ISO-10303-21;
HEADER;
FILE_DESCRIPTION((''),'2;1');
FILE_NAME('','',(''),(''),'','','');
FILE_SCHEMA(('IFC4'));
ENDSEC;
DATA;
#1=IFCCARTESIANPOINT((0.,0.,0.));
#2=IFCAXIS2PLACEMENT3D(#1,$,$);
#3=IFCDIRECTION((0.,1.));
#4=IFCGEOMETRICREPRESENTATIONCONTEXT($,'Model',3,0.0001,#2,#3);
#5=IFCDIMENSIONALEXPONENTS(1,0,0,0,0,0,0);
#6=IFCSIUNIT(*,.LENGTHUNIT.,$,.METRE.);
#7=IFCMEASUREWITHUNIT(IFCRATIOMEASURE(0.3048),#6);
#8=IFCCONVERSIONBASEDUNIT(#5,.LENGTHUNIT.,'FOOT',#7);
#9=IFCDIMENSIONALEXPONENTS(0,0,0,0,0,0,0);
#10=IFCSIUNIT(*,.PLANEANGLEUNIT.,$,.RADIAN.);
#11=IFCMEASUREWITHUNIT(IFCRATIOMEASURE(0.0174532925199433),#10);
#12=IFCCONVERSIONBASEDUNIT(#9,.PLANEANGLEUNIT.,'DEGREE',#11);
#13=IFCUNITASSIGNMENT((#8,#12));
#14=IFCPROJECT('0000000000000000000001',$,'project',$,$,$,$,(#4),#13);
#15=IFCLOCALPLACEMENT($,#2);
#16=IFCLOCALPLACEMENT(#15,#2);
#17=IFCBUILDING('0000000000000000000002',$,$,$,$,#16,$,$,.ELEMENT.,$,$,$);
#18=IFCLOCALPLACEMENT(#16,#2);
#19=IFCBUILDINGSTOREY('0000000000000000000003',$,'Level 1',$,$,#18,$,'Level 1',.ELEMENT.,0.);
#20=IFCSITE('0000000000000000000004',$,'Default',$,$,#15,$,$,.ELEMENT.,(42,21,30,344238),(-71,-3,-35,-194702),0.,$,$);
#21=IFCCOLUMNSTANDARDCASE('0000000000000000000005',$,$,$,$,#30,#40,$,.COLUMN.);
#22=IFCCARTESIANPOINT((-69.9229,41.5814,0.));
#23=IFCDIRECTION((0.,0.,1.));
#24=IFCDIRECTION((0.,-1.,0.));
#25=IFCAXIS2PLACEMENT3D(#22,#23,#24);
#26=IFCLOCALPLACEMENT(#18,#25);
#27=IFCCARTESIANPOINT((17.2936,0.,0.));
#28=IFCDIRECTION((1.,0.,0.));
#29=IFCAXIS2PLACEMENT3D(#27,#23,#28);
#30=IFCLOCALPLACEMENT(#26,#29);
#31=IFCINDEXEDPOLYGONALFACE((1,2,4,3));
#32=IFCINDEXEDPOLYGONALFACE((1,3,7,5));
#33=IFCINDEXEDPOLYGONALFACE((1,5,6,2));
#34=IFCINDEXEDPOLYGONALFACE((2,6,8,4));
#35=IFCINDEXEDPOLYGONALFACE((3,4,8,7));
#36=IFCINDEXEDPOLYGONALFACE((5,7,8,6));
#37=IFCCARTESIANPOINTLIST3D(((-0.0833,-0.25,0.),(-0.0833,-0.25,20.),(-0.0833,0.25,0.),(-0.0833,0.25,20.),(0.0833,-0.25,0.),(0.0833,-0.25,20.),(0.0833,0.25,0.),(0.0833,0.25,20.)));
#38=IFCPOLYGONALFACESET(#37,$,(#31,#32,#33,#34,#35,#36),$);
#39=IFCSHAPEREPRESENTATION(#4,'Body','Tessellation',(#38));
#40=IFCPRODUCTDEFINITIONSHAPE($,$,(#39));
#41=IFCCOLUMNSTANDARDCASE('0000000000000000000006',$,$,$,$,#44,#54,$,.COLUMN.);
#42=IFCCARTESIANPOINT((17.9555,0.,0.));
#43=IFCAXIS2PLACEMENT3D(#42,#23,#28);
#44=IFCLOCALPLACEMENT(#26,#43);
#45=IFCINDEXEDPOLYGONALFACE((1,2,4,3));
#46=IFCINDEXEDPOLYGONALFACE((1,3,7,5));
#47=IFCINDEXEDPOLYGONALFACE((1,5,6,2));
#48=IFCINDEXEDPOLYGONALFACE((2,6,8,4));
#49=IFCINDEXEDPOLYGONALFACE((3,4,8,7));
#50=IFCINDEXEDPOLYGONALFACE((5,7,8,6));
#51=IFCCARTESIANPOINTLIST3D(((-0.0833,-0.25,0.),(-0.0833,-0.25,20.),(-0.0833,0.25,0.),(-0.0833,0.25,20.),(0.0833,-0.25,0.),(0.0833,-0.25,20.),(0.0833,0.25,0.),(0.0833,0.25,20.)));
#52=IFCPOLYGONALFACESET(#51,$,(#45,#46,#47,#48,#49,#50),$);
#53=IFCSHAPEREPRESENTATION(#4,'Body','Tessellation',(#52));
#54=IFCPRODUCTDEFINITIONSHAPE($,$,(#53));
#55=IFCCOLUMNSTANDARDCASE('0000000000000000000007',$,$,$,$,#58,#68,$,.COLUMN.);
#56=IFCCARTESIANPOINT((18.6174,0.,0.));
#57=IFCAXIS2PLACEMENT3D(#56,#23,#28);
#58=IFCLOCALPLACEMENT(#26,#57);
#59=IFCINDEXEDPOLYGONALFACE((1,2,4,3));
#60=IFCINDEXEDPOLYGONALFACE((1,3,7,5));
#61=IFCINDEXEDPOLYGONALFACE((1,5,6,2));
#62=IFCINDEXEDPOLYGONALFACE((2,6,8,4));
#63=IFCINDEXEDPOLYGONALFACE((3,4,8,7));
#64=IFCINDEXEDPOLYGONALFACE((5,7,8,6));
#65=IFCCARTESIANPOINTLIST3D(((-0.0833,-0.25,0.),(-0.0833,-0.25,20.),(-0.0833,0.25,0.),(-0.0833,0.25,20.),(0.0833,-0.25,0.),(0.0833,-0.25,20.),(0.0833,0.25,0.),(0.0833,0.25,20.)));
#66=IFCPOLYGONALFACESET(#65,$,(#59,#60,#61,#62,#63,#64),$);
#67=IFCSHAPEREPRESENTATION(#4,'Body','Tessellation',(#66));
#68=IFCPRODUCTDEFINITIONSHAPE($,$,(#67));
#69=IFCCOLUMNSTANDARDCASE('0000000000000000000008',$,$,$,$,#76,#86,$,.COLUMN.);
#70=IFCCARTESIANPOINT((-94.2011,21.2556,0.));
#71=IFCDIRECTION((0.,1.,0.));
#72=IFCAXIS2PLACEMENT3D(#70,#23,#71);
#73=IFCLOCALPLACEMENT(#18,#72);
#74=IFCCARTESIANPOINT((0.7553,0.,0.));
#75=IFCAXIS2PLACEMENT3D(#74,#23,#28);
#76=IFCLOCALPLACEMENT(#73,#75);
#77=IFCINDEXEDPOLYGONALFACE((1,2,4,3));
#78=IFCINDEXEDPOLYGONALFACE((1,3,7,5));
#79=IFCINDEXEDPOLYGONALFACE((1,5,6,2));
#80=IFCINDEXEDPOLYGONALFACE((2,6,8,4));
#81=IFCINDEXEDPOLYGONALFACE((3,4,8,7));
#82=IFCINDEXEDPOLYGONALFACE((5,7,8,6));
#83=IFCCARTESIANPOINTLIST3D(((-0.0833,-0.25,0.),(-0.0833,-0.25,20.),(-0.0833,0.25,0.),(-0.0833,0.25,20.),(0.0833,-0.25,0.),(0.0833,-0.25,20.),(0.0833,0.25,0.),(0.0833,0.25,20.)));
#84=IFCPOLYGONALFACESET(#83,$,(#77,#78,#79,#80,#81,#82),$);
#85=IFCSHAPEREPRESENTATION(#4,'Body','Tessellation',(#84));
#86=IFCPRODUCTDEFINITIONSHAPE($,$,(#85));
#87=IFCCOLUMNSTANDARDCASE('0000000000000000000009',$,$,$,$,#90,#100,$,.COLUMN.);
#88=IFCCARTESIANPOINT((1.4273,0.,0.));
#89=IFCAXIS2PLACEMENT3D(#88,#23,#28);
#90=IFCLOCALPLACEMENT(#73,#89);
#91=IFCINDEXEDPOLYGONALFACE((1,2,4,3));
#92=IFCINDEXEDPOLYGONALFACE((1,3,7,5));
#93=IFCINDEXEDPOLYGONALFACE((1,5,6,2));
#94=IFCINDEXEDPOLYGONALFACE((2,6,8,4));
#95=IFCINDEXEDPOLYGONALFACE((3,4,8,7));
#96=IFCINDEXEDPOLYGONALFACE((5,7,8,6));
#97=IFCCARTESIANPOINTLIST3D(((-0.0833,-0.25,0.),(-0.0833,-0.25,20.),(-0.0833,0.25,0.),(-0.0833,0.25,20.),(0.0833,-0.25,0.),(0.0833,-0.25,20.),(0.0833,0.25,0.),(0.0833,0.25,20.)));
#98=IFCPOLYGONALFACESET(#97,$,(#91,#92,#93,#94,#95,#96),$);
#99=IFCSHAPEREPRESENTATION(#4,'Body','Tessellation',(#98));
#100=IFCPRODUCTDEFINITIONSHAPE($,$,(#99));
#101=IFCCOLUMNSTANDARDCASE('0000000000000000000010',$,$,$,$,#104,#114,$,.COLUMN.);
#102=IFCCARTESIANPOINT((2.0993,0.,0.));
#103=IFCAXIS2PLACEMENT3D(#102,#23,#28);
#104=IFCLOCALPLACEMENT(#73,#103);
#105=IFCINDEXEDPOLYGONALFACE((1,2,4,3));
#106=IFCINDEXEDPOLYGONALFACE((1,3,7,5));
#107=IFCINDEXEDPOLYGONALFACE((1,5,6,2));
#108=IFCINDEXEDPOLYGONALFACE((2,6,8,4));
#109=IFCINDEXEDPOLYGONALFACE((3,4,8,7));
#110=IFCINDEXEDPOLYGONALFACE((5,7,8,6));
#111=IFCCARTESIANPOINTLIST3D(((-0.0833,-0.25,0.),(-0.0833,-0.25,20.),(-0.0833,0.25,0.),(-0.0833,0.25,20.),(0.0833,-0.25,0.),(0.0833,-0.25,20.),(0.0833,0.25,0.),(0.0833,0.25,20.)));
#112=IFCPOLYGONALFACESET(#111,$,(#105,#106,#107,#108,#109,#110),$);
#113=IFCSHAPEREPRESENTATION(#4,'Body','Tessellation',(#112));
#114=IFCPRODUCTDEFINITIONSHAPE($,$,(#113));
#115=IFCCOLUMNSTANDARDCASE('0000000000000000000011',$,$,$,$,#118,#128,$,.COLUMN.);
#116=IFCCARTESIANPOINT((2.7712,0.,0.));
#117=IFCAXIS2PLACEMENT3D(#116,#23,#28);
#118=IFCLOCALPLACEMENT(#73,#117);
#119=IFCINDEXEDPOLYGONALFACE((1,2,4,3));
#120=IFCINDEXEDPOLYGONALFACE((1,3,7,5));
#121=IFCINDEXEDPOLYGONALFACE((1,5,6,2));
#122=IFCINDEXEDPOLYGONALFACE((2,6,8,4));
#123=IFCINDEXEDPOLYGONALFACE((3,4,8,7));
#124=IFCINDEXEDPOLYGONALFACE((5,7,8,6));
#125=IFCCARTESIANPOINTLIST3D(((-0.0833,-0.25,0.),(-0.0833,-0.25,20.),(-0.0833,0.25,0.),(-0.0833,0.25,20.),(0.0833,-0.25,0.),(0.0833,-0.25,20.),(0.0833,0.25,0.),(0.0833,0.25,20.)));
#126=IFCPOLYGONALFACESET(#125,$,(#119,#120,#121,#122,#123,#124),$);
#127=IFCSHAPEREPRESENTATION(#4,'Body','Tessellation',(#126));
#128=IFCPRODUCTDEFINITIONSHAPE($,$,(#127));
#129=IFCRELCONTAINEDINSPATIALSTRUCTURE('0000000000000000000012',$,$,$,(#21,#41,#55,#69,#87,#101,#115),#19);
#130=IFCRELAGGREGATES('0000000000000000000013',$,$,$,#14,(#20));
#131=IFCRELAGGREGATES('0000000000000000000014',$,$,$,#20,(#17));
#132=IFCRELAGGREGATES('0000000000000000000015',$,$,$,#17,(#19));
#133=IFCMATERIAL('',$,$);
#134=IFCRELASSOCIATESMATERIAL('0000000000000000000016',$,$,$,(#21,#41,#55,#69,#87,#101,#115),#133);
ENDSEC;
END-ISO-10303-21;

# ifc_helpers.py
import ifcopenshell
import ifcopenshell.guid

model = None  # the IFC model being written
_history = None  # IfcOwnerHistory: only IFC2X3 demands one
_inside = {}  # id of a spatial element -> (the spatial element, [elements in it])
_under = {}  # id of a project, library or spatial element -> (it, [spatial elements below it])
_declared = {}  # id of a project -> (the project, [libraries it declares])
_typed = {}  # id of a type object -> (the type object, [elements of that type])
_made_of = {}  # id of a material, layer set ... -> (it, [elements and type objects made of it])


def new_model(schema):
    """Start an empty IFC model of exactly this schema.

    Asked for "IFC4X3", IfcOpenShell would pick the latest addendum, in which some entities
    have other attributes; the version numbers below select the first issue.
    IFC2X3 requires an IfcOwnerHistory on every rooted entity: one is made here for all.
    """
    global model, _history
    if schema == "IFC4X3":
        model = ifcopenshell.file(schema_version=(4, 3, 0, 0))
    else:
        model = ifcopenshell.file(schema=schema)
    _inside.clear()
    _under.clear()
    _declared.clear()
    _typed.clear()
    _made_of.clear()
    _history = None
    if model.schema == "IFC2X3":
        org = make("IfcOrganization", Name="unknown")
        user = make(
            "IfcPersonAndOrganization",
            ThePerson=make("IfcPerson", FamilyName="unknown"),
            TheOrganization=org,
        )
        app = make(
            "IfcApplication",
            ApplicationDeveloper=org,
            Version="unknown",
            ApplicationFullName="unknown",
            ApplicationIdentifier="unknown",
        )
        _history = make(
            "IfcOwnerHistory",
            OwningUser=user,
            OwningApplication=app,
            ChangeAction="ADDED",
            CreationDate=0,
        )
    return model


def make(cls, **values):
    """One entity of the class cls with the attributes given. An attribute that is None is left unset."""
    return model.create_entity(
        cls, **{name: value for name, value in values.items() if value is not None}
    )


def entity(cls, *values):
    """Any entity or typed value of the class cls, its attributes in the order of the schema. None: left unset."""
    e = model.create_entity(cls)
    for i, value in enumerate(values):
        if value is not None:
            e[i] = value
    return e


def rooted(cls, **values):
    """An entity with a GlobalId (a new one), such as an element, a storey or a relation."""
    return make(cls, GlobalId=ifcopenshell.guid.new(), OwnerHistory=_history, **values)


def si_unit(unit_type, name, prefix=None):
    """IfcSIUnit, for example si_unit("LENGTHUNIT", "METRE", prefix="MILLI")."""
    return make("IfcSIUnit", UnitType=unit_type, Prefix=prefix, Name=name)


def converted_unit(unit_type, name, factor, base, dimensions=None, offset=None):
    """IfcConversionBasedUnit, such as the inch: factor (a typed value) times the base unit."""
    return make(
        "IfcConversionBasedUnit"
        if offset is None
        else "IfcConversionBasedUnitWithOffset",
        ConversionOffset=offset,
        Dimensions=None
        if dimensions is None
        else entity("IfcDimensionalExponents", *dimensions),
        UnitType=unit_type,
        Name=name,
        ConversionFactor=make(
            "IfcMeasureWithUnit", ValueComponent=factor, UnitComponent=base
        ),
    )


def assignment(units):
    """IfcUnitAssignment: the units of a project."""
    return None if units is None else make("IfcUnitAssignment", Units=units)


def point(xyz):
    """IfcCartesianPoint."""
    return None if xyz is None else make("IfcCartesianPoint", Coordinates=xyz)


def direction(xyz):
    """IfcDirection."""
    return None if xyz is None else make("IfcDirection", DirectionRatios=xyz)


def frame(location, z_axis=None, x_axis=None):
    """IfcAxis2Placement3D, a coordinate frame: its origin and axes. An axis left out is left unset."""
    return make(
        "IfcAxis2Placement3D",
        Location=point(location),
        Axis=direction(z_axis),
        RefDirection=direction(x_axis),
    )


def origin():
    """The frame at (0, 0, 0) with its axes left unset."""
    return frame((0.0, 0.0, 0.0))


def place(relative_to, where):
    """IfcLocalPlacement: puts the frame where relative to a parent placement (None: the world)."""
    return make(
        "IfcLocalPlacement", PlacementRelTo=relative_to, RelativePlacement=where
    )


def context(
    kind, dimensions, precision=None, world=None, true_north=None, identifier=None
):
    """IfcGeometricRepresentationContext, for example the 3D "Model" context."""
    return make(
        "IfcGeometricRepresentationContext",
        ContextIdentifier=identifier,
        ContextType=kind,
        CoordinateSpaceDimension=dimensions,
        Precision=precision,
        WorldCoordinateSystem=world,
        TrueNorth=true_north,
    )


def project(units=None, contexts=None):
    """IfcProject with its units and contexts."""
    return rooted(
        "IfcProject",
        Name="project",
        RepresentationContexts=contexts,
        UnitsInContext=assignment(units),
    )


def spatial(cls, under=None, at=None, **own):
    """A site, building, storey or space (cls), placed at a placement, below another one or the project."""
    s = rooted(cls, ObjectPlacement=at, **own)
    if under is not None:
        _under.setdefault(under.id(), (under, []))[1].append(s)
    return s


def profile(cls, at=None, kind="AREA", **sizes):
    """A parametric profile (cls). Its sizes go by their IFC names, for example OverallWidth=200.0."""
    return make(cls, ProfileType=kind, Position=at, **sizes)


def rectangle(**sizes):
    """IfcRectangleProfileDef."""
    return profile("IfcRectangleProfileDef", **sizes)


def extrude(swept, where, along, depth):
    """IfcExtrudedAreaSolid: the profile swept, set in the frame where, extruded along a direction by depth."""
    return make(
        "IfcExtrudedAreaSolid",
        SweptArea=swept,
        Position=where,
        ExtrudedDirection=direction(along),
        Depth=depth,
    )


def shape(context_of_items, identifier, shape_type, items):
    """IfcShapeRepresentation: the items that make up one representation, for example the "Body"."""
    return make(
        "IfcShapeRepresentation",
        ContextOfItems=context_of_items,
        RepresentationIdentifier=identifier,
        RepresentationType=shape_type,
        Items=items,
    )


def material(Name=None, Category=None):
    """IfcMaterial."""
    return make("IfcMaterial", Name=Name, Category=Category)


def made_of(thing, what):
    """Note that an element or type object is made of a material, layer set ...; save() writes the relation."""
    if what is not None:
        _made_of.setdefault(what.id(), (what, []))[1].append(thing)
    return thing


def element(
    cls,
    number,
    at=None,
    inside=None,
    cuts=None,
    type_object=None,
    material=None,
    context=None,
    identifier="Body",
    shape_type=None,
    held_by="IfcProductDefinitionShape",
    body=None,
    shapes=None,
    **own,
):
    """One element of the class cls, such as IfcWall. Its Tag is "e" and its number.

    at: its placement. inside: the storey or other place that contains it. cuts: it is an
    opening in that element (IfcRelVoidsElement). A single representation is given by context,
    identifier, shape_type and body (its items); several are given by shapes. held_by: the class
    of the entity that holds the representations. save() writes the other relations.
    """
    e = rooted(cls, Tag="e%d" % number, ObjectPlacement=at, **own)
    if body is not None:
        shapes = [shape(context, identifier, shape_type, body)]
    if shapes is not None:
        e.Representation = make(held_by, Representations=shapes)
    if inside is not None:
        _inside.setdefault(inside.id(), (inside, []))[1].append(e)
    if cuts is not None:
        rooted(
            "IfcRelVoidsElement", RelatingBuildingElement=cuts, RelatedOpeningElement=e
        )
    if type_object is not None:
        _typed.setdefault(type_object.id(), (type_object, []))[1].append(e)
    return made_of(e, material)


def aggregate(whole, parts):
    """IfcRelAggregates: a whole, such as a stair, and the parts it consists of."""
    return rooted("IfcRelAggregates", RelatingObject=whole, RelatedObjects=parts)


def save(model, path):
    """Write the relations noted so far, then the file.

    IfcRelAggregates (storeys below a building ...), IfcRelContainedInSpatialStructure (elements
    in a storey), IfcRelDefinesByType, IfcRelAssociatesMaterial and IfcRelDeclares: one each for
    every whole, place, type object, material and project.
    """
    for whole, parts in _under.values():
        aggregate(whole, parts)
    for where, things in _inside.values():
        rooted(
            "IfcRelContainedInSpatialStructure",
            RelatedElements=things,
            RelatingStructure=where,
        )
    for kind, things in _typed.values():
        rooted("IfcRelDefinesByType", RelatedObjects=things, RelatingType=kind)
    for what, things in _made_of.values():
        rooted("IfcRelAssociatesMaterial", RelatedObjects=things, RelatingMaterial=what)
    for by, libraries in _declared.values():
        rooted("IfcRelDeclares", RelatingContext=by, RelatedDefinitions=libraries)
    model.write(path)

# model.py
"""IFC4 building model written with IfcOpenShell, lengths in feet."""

from ifc_helpers import new_model, entity, si_unit, converted_unit, direction, frame, origin, place, context, project, spatial, rectangle, extrude, material, element, save


model = new_model("IFC4")

# Units and contexts
model_context = context("Model", 3, precision=0.0001, world=origin(), true_north=direction((0.0, 1.0)))
ifc_project = project(units=[converted_unit("LENGTHUNIT", "FOOT", entity("IfcRatioMeasure", 0.3048), si_unit("LENGTHUNIT", "METRE"), dimensions=[1, 0, 0, 0, 0, 0, 0]), converted_unit("PLANEANGLEUNIT", "DEGREE", entity("IfcRatioMeasure", 0.0174532925199433), si_unit("PLANEANGLEUNIT", "RADIAN"), dimensions=[0, 0, 0, 0, 0, 0, 0])], contexts=[model_context])

# Site, building, storey
site_placement = place(None, origin())
site = spatial("IfcSite", under=ifc_project, at=site_placement, Name="Default", CompositionType="ELEMENT", RefLatitude=(42, 21, 30, 344238), RefLongitude=(-71, -3, -35, -194702), RefElevation=0.0)
building_placement = place(site_placement, origin())
building = spatial("IfcBuilding", under=site, at=building_placement, CompositionType="ELEMENT")
storey_placement = place(building_placement, origin())
storey = spatial("IfcBuildingStorey", under=building, at=storey_placement, Name="Level 1", LongName="Level 1", CompositionType="ELEMENT", Elevation=0.0)

# Columns
ifc_material_1 = material(Name="")
placement_1 = place(storey_placement, frame((-69.9229, 41.5814, 0.0), z_axis=(0.0, 0.0, 1.0), x_axis=(0.0, -1.0, 0.0)))
for number, where, z_axis, x_axis in (
    (1, (17.2936, 0.0, 0.0), (0.0, 0.0, 1.0), (1.0, 0.0, 0.0)),
    (2, (17.9555, 0.0, 0.0), (0.0, 0.0, 1.0), (1.0, 0.0, 0.0)),
    (3, (18.6174, 0.0, 0.0), (0.0, 0.0, 1.0), (1.0, 0.0, 0.0)),
):
    element("IfcColumnStandardCase", number, at=place(placement_1, frame(where, z_axis=z_axis, x_axis=x_axis)), inside=storey, material=ifc_material_1, PredefinedType="COLUMN", context=model_context, shape_type="SweptSolid", body=[
        extrude(rectangle(XDim=0.1667, YDim=0.5), origin(), (0.0, 0.0, 1.0), 20.0),
    ])
wall_1_placement = place(storey_placement, frame((-94.2011, 21.2556, 0.0), z_axis=(0.0, 0.0, 1.0), x_axis=(0.0, 1.0, 0.0)))
for number, where, z_axis, x_axis in (
    (4, (0.7553, 0.0, 0.0), (0.0, 0.0, 1.0), (1.0, 0.0, 0.0)),
    (5, (1.4273, 0.0, 0.0), (0.0, 0.0, 1.0), (1.0, 0.0, 0.0)),
    (6, (2.0993, 0.0, 0.0), (0.0, 0.0, 1.0), (1.0, 0.0, 0.0)),
    (7, (2.7712, 0.0, 0.0), (0.0, 0.0, 1.0), (1.0, 0.0, 0.0)),
):
    element("IfcColumnStandardCase", number, at=place(wall_1_placement, frame(where, z_axis=z_axis, x_axis=x_axis)), inside=storey, material=ifc_material_1, PredefinedType="COLUMN", context=model_context, shape_type="SweptSolid", body=[
        extrude(rectangle(XDim=0.1667, YDim=0.5), origin(), (0.0, 0.0, 1.0), 20.0),
    ])

save(model, "model.ifc")
